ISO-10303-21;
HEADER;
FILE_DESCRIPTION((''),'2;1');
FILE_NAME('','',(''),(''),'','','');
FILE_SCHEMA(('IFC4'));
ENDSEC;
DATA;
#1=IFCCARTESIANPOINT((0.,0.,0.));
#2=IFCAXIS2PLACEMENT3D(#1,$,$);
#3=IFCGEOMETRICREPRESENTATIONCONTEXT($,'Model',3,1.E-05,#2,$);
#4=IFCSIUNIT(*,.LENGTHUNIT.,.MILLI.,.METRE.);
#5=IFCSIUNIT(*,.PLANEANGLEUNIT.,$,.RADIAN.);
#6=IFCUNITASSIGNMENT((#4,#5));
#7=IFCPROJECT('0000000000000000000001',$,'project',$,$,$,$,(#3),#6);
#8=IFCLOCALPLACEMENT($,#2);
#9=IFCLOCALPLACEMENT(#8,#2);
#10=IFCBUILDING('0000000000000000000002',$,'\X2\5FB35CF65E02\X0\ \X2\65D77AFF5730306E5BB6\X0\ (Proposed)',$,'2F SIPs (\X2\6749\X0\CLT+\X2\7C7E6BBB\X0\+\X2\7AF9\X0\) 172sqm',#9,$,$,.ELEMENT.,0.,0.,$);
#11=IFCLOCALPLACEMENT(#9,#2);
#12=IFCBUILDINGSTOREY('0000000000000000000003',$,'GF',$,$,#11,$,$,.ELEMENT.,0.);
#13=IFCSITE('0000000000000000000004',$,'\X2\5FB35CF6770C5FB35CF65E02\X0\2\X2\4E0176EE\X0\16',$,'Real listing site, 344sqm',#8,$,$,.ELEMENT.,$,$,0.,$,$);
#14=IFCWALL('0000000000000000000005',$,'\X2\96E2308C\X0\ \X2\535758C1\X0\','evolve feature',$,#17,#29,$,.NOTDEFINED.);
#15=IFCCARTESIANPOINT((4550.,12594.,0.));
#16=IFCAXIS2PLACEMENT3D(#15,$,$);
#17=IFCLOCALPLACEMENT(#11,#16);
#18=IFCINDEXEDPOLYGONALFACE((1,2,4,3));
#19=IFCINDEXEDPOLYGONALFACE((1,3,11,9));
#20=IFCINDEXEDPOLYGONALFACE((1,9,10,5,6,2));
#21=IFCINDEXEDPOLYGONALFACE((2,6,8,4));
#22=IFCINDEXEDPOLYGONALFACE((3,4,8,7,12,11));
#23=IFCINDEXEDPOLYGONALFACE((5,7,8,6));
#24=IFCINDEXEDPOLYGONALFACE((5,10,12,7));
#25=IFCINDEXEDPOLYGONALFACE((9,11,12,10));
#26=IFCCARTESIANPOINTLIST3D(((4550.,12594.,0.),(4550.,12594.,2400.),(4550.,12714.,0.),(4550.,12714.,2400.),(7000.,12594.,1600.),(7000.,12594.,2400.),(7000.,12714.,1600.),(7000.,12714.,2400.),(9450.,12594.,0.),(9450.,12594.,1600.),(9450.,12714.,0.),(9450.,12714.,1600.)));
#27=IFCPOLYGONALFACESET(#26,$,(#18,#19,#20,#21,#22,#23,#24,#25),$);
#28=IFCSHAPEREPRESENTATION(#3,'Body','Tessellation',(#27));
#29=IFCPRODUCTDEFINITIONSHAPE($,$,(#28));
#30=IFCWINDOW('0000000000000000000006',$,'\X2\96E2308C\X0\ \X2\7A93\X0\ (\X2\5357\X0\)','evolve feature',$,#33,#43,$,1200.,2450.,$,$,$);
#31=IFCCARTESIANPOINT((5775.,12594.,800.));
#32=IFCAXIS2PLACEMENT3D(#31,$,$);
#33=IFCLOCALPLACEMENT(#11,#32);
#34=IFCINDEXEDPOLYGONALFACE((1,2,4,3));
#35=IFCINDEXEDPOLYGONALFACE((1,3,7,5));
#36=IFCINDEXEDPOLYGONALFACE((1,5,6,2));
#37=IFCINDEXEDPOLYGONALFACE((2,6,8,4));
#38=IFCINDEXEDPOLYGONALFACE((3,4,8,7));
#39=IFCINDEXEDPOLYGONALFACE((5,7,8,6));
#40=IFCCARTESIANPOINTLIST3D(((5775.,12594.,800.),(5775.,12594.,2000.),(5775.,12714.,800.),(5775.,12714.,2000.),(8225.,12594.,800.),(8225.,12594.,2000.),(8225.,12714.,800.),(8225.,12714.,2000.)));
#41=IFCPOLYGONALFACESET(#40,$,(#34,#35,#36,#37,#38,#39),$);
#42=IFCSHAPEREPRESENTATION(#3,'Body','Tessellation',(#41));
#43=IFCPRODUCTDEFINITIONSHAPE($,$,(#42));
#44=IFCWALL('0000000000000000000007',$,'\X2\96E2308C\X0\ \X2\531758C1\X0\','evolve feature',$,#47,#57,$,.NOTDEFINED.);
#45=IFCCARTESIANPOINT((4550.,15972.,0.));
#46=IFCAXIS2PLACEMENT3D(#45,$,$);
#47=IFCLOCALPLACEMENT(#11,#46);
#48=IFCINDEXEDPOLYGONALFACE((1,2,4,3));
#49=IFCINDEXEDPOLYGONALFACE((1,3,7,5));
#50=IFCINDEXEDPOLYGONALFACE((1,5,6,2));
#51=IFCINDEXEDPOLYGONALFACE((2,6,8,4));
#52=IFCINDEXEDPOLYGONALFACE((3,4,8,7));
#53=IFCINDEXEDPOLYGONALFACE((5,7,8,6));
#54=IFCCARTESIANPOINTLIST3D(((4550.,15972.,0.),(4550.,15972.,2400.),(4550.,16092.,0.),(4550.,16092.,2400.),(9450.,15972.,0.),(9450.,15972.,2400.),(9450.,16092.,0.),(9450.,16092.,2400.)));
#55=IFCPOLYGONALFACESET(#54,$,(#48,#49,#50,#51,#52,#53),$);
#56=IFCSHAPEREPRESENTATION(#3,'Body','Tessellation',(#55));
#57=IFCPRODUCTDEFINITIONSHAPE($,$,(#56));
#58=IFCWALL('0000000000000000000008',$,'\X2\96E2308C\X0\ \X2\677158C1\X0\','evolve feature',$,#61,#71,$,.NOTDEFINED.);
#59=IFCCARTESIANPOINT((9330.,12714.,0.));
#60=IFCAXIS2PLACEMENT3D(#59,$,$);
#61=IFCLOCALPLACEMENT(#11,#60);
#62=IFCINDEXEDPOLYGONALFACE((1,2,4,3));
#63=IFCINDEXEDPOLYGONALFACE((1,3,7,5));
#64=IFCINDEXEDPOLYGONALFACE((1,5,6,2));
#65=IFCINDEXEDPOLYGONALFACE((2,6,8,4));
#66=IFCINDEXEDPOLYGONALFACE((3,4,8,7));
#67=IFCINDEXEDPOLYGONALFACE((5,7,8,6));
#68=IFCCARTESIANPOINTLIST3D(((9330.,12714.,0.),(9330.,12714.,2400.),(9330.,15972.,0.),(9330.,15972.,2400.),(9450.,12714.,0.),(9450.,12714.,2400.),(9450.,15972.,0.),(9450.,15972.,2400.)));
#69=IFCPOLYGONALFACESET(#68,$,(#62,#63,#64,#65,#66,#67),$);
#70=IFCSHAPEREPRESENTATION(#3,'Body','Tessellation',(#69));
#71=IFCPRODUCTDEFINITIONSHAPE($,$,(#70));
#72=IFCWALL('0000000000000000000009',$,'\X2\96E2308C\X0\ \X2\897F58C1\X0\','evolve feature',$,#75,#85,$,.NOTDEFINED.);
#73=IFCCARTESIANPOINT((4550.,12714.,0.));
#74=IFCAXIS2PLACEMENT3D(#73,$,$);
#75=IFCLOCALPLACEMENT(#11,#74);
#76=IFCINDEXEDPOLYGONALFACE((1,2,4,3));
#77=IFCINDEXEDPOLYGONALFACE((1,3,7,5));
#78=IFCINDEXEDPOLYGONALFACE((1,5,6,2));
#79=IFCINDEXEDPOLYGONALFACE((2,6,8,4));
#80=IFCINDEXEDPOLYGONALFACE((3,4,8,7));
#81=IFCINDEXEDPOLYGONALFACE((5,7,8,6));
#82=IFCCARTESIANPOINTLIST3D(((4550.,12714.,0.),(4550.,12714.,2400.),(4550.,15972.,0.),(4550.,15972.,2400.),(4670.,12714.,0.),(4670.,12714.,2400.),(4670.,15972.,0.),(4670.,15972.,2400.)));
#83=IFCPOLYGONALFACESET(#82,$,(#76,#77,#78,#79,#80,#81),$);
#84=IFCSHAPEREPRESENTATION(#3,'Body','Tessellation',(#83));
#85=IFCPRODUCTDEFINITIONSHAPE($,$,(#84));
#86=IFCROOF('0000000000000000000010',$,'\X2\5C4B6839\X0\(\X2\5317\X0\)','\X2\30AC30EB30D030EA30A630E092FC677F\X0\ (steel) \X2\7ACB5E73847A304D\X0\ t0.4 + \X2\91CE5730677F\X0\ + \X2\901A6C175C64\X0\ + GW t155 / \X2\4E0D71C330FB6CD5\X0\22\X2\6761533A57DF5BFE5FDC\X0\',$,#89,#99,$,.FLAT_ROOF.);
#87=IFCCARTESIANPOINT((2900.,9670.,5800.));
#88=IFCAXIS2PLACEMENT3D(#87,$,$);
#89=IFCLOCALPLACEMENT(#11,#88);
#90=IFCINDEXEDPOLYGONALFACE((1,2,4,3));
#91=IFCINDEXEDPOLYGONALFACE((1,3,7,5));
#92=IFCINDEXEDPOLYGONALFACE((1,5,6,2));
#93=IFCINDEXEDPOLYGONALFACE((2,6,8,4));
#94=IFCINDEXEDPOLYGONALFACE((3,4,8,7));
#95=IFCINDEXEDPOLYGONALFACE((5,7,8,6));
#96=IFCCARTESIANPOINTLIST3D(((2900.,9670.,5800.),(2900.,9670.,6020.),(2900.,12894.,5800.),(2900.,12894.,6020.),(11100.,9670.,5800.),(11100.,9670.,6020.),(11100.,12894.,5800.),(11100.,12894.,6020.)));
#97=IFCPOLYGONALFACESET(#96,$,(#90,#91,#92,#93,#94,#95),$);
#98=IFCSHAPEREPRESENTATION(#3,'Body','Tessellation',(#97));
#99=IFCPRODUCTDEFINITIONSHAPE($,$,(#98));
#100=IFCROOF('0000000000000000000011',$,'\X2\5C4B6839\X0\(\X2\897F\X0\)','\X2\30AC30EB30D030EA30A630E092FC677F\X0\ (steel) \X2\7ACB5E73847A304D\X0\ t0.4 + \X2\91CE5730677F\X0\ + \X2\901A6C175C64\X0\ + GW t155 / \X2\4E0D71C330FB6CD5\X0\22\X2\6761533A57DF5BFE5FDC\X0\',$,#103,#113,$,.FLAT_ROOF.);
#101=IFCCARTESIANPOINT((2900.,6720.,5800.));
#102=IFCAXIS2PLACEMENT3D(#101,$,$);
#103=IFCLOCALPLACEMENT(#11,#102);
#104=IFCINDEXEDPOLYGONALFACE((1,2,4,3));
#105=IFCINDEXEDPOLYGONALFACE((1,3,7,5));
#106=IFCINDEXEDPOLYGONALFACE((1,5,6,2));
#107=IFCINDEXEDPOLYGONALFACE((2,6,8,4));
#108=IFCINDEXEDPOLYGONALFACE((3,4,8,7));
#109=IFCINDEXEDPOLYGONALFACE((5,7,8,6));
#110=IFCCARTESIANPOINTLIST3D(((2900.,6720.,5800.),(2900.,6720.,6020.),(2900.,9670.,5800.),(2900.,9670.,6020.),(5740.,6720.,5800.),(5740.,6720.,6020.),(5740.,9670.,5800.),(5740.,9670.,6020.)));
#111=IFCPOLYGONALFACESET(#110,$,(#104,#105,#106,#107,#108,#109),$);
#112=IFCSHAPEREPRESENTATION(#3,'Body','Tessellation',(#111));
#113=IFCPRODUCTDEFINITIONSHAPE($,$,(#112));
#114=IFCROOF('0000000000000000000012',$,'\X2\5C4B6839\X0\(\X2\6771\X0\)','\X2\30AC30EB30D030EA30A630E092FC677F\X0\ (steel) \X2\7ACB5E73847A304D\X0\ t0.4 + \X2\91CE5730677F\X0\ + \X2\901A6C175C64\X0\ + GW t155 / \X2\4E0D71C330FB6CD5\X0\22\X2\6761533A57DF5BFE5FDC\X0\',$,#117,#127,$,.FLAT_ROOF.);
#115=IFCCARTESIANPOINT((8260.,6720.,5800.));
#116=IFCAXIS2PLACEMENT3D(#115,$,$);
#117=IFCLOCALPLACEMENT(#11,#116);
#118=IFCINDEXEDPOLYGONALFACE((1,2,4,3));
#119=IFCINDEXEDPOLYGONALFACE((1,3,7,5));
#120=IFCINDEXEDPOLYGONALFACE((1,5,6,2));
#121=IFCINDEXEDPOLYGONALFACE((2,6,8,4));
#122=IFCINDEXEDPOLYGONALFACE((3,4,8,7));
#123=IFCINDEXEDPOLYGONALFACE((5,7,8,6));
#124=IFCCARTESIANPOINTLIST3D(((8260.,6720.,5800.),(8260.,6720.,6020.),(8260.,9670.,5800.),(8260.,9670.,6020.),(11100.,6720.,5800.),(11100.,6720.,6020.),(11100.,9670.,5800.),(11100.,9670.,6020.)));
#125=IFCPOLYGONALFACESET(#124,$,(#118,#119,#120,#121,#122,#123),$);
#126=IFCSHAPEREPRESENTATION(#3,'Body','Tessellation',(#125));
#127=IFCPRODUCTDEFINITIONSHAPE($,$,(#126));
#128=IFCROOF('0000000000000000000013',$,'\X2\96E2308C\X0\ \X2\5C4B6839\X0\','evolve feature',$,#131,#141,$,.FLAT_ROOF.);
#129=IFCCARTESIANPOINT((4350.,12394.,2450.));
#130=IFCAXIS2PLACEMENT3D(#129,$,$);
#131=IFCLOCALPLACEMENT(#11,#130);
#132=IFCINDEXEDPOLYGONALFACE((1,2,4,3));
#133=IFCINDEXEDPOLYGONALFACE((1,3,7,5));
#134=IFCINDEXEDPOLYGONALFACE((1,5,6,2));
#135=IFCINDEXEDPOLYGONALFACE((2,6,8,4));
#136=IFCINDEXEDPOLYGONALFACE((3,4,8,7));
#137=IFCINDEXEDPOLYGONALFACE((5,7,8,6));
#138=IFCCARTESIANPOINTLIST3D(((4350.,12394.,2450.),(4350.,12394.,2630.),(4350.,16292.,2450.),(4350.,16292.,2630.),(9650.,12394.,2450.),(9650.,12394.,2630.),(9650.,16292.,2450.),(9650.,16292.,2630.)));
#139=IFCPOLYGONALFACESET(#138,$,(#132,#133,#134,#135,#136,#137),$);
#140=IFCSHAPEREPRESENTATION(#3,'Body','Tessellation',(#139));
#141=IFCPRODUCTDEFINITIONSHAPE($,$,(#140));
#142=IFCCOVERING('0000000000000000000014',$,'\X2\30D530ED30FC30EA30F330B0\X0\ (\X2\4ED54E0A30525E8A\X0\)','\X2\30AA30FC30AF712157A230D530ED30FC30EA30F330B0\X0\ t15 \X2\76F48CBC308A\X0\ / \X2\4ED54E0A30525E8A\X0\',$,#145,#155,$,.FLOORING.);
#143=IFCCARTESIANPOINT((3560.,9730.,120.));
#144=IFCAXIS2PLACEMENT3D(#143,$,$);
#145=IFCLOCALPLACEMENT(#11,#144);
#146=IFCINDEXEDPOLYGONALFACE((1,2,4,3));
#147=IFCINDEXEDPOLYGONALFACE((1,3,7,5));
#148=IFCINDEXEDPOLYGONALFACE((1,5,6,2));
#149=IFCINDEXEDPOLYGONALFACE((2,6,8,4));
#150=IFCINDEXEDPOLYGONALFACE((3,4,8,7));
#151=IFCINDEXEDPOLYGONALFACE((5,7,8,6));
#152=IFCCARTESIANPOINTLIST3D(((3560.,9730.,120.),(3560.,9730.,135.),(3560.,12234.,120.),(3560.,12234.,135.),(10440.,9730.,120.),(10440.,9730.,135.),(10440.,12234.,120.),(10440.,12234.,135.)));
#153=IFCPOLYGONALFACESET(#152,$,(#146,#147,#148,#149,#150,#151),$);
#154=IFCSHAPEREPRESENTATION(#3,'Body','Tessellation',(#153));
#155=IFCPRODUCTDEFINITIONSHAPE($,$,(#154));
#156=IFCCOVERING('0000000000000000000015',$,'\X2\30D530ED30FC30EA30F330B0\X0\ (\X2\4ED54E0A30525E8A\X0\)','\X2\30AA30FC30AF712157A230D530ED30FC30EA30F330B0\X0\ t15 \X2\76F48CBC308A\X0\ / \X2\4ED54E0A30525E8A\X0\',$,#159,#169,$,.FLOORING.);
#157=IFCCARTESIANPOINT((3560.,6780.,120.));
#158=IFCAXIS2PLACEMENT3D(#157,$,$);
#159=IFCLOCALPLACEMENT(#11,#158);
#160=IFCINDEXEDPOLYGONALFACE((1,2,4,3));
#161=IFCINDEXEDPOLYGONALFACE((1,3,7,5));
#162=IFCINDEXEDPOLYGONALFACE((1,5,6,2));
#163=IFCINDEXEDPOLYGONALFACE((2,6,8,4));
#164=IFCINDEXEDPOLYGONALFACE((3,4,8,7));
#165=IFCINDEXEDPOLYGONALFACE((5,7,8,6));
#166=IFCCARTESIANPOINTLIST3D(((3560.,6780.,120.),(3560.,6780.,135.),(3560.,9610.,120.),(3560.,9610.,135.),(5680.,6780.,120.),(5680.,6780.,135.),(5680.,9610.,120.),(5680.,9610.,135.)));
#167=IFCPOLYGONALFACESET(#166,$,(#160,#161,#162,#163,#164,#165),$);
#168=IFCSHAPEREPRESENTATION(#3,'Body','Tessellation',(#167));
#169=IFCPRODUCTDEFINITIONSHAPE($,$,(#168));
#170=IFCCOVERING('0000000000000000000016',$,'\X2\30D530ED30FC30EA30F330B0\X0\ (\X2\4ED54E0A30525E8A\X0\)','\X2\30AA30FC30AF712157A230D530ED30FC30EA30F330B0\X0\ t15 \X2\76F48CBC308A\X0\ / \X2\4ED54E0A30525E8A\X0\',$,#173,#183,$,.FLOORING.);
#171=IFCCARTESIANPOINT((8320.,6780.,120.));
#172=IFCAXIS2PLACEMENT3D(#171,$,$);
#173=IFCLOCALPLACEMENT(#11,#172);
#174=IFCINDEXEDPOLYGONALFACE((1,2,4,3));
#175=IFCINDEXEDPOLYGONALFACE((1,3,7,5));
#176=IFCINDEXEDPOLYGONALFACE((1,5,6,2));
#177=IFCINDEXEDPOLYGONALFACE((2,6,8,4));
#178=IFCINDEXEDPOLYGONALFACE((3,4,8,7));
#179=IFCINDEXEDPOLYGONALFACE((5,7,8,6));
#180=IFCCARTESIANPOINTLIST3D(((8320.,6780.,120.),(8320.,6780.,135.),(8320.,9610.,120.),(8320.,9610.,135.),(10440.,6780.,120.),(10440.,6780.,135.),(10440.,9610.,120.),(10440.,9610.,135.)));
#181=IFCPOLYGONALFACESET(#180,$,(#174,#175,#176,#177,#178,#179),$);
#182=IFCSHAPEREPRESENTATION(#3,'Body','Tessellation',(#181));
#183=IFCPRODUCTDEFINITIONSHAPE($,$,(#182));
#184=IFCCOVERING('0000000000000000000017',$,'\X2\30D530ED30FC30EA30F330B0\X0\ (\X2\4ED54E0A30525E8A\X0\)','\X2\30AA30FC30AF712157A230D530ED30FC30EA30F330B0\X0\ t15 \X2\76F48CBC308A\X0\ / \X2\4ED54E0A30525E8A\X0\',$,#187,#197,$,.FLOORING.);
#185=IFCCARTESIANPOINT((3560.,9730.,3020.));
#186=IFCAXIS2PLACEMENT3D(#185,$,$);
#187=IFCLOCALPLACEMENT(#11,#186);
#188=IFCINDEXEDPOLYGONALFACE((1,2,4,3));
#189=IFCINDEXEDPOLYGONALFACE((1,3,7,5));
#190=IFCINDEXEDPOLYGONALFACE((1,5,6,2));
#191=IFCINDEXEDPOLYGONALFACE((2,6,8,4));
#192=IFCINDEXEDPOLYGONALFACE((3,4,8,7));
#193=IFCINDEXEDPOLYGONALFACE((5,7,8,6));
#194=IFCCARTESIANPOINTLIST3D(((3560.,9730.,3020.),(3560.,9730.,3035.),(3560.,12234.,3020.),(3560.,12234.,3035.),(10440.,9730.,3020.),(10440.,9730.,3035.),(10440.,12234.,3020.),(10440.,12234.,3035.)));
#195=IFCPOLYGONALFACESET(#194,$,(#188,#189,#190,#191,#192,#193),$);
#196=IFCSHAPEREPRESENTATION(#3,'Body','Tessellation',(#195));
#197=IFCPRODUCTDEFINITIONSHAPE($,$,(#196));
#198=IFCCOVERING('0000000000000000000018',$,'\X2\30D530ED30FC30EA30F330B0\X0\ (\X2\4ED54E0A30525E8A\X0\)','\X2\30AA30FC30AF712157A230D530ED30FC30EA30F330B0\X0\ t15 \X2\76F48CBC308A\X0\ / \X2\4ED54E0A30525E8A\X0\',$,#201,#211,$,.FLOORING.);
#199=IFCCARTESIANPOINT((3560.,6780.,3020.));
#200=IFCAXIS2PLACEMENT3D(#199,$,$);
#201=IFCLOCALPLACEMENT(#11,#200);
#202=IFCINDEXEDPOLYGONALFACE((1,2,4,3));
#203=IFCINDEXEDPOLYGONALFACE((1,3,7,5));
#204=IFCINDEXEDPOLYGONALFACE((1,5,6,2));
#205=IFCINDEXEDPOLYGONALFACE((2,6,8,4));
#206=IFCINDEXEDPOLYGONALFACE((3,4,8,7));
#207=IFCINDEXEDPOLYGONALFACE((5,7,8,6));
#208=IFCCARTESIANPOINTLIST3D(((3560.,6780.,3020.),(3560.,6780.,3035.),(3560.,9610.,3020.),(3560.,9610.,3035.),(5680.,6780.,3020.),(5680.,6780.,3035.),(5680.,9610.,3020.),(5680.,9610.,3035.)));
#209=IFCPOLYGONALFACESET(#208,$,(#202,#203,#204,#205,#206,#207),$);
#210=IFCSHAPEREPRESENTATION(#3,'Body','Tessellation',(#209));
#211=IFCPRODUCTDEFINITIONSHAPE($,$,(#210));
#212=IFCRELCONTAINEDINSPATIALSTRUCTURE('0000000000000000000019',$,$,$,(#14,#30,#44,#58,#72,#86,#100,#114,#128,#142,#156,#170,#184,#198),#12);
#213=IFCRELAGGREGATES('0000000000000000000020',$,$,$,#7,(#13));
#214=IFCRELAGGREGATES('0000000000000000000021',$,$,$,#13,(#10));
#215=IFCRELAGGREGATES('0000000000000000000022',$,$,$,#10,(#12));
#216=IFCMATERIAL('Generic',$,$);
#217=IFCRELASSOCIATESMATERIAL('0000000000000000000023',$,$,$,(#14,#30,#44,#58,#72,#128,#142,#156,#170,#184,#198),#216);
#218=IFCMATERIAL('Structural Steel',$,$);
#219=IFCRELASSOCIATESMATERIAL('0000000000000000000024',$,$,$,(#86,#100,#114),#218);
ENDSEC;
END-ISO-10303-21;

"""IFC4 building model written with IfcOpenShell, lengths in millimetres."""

from ifc_helpers import new_model, si_unit, frame, frame_2d, origin, place, context, project, spatial, rectangle, extrude, material, element, fill, save


model = new_model("IFC4")

# Units and contexts
model_context = context("Model", 3, precision=1e-05, world=origin())
ifc_project = project(units=[si_unit("LENGTHUNIT", "METRE", prefix="MILLI"), si_unit("PLANEANGLEUNIT", "RADIAN")], contexts=[model_context])

# Site, building, storey
site_placement = place(None, origin())
site = spatial("IfcSite", under=ifc_project, at=site_placement, Name="徳島県徳島市2丁目16", ObjectType="Real listing site, 344sqm", CompositionType="ELEMENT", RefElevation=0.0)
building_placement = place(site_placement, origin())
building = spatial("IfcBuilding", under=site, at=building_placement, Name="徳島市 旗竿地の家 (Proposed)", ObjectType="2F SIPs (杉CLT+籾殻+竹) 172sqm", CompositionType="ELEMENT", ElevationOfRefHeight=0.0, ElevationOfTerrain=0.0)
storey_placement = place(building_placement, origin())
storey = spatial("IfcBuildingStorey", under=building, at=storey_placement, Name="GF", CompositionType="ELEMENT", Elevation=0.0)

# Shared definitions
ifc_material_1 = material(Name="Generic")

# Wall, opening, window
wall_1_placement = place(storey_placement, frame((4550.0, 12594.0, 0.0)))
wall_1 = element("IfcWall", 1, at=wall_1_placement, inside=storey, material=ifc_material_1, Name="離れ 南壁", Description="evolve feature", PredefinedType="NOTDEFINED", context=model_context, shape_type="SweptSolid", body=[
    extrude(rectangle(XDim=4900.0, YDim=120.0, at=frame_2d((2450.0, 60.0))), frame((4550.0, 12594.0, 0.0)), (0.0, 0.0, 1.0), 2400.0),
])
opening_1_placement = place(storey_placement, frame((5775.0, 12594.0, 800.0)))
opening_1 = element("IfcOpeningElement", 2, at=opening_1_placement, cuts=wall_1, PredefinedType="NOTDEFINED", context=model_context, shape_type="SweptSolid", body=[
    extrude(rectangle(XDim=2450.0, YDim=120.0, at=frame_2d((1225.0, 60.0))), frame((5775.0, 12594.0, 800.0)), (0.0, 0.0, 1.0), 1200.0),
])
window_1_placement = place(storey_placement, frame((5775.0, 12594.0, 800.0)))
window_1 = element("IfcWindow", 3, at=window_1_placement, inside=storey, material=ifc_material_1, Name="離れ 窓 (南)", Description="evolve feature", OverallHeight=1200.0, OverallWidth=2450.0, context=model_context, shape_type="SweptSolid", body=[
    extrude(rectangle(XDim=2450.0, YDim=120.0, at=frame_2d((1225.0, 60.0))), frame((5775.0, 12594.0, 800.0)), (0.0, 0.0, 1.0), 1200.0),
])
fill(opening_1, window_1)

# Walls
wall_2_placement = place(storey_placement, frame((4550.0, 15972.0, 0.0)))
element("IfcWall", 4, at=wall_2_placement, inside=storey, material=ifc_material_1, Name="離れ 北壁", Description="evolve feature", PredefinedType="NOTDEFINED", context=model_context, shape_type="SweptSolid", body=[
    extrude(rectangle(XDim=4900.0, YDim=120.0, at=frame_2d((2450.0, 60.0))), frame((4550.0, 15972.0, 0.0)), (0.0, 0.0, 1.0), 2400.0),
])
wall_3_placement = place(storey_placement, frame((9330.0, 12714.0, 0.0)))
element("IfcWall", 5, at=wall_3_placement, inside=storey, material=ifc_material_1, Name="離れ 東壁", Description="evolve feature", PredefinedType="NOTDEFINED", context=model_context, shape_type="SweptSolid", body=[
    extrude(rectangle(XDim=120.0, YDim=3258.0, at=frame_2d((60.0, 1629.0))), frame((9330.0, 12714.0, 0.0)), (0.0, 0.0, 1.0), 2400.0),
])
wall_4_placement = place(storey_placement, frame((4550.0, 12714.0, 0.0)))
element("IfcWall", 6, at=wall_4_placement, inside=storey, material=ifc_material_1, Name="離れ 西壁", Description="evolve feature", PredefinedType="NOTDEFINED", context=model_context, shape_type="SweptSolid", body=[
    extrude(rectangle(XDim=120.0, YDim=3258.0, at=frame_2d((60.0, 1629.0))), frame((4550.0, 12714.0, 0.0)), (0.0, 0.0, 1.0), 2400.0),
])

# Roofs
ifc_material_2 = material(Name="Structural Steel")
for number, where, name in (
    (7, (2900.0, 9670.0, 5800.0), "屋根(北)"),
):
    element("IfcRoof", number, at=place(storey_placement, frame(where)), inside=storey, material=ifc_material_2, Name=name, Description="ガルバリウム鋼板 (steel) 立平葺き t0.4 + 野地板 + 通気層 + GW t155 / 不燃・法22条区域対応", PredefinedType="FLAT_ROOF", context=model_context, shape_type="SweptSolid", body=[
        extrude(rectangle(XDim=8200.0, YDim=3224.0, at=frame_2d((4100.0, 1612.0))), frame((2900.0, 9670.0, 5800.0)), (0.0, 0.0, 1.0), 220.0),
    ])
roof_1_placement = place(storey_placement, frame((2900.0, 6720.0, 5800.0)))
element("IfcRoof", 8, at=roof_1_placement, inside=storey, material=ifc_material_2, Name="屋根(西)", Description="ガルバリウム鋼板 (steel) 立平葺き t0.4 + 野地板 + 通気層 + GW t155 / 不燃・法22条区域対応", PredefinedType="FLAT_ROOF", context=model_context, shape_type="SweptSolid", body=[
    extrude(rectangle(XDim=2840.0, YDim=2950.0, at=frame_2d((1420.0, 1475.0))), frame((2900.0, 6720.0, 5800.0)), (0.0, 0.0, 1.0), 220.0),
])
roof_2_placement = place(storey_placement, frame((8260.0, 6720.0, 5800.0)))
element("IfcRoof", 9, at=roof_2_placement, inside=storey, material=ifc_material_2, Name="屋根(東)", Description="ガルバリウム鋼板 (steel) 立平葺き t0.4 + 野地板 + 通気層 + GW t155 / 不燃・法22条区域対応", PredefinedType="FLAT_ROOF", context=model_context, shape_type="SweptSolid", body=[
    extrude(rectangle(XDim=2840.0, YDim=2950.0, at=frame_2d((1420.0, 1475.0))), frame((8260.0, 6720.0, 5800.0)), (0.0, 0.0, 1.0), 220.0),
])
roof_3_placement = place(storey_placement, frame((4350.0, 12394.0, 2450.0)))
element("IfcRoof", 10, at=roof_3_placement, inside=storey, material=ifc_material_1, Name="離れ 屋根", Description="evolve feature", PredefinedType="FLAT_ROOF", context=model_context, shape_type="SweptSolid", body=[
    extrude(rectangle(XDim=5300.0, YDim=3898.0, at=frame_2d((2650.0, 1949.0))), frame((4350.0, 12394.0, 2450.0)), (0.0, 0.0, 1.0), 180.0),
])

# Coverings
covering_1_placement = place(storey_placement, frame((3560.0, 9730.0, 120.0)))
element("IfcCovering", 11, at=covering_1_placement, inside=storey, material=ifc_material_1, Name="フローリング (仕上げ床)", Description="オーク無垢フローリング t15 直貼り / 仕上げ床", PredefinedType="FLOORING", context=model_context, shape_type="SweptSolid", body=[
    extrude(rectangle(XDim=6880.0, YDim=2504.0, at=frame_2d((3440.0, 1252.0))), frame((3560.0, 9730.0, 120.0)), (0.0, 0.0, 1.0), 15.0),
])
covering_2_placement = place(storey_placement, frame((3560.0, 6780.0, 120.0)))
element("IfcCovering", 12, at=covering_2_placement, inside=storey, material=ifc_material_1, Name="フローリング (仕上げ床)", Description="オーク無垢フローリング t15 直貼り / 仕上げ床", PredefinedType="FLOORING", context=model_context, shape_type="SweptSolid", body=[
    extrude(rectangle(XDim=2120.0, YDim=2830.0, at=frame_2d((1060.0, 1415.0))), frame((3560.0, 6780.0, 120.0)), (0.0, 0.0, 1.0), 15.0),
])
covering_3_placement = place(storey_placement, frame((8320.0, 6780.0, 120.0)))
element("IfcCovering", 13, at=covering_3_placement, inside=storey, material=ifc_material_1, Name="フローリング (仕上げ床)", Description="オーク無垢フローリング t15 直貼り / 仕上げ床", PredefinedType="FLOORING", context=model_context, shape_type="SweptSolid", body=[
    extrude(rectangle(XDim=2120.0, YDim=2830.0, at=frame_2d((1060.0, 1415.0))), frame((8320.0, 6780.0, 120.0)), (0.0, 0.0, 1.0), 15.0),
])
covering_4_placement = place(storey_placement, frame((3560.0, 9730.0, 3020.0)))
element("IfcCovering", 14, at=covering_4_placement, inside=storey, material=ifc_material_1, Name="フローリング (仕上げ床)", Description="オーク無垢フローリング t15 直貼り / 仕上げ床", PredefinedType="FLOORING", context=model_context, shape_type="SweptSolid", body=[
    extrude(rectangle(XDim=6880.0, YDim=2504.0, at=frame_2d((3440.0, 1252.0))), frame((3560.0, 9730.0, 3020.0)), (0.0, 0.0, 1.0), 15.0),
])
covering_5_placement = place(storey_placement, frame((3560.0, 6780.0, 3020.0)))
element("IfcCovering", 15, at=covering_5_placement, inside=storey, material=ifc_material_1, Name="フローリング (仕上げ床)", Description="オーク無垢フローリング t15 直貼り / 仕上げ床", PredefinedType="FLOORING", context=model_context, shape_type="SweptSolid", body=[
    extrude(rectangle(XDim=2120.0, YDim=2830.0, at=frame_2d((1060.0, 1415.0))), frame((3560.0, 6780.0, 3020.0)), (0.0, 0.0, 1.0), 15.0),
])

save(model, "model.ifc")
